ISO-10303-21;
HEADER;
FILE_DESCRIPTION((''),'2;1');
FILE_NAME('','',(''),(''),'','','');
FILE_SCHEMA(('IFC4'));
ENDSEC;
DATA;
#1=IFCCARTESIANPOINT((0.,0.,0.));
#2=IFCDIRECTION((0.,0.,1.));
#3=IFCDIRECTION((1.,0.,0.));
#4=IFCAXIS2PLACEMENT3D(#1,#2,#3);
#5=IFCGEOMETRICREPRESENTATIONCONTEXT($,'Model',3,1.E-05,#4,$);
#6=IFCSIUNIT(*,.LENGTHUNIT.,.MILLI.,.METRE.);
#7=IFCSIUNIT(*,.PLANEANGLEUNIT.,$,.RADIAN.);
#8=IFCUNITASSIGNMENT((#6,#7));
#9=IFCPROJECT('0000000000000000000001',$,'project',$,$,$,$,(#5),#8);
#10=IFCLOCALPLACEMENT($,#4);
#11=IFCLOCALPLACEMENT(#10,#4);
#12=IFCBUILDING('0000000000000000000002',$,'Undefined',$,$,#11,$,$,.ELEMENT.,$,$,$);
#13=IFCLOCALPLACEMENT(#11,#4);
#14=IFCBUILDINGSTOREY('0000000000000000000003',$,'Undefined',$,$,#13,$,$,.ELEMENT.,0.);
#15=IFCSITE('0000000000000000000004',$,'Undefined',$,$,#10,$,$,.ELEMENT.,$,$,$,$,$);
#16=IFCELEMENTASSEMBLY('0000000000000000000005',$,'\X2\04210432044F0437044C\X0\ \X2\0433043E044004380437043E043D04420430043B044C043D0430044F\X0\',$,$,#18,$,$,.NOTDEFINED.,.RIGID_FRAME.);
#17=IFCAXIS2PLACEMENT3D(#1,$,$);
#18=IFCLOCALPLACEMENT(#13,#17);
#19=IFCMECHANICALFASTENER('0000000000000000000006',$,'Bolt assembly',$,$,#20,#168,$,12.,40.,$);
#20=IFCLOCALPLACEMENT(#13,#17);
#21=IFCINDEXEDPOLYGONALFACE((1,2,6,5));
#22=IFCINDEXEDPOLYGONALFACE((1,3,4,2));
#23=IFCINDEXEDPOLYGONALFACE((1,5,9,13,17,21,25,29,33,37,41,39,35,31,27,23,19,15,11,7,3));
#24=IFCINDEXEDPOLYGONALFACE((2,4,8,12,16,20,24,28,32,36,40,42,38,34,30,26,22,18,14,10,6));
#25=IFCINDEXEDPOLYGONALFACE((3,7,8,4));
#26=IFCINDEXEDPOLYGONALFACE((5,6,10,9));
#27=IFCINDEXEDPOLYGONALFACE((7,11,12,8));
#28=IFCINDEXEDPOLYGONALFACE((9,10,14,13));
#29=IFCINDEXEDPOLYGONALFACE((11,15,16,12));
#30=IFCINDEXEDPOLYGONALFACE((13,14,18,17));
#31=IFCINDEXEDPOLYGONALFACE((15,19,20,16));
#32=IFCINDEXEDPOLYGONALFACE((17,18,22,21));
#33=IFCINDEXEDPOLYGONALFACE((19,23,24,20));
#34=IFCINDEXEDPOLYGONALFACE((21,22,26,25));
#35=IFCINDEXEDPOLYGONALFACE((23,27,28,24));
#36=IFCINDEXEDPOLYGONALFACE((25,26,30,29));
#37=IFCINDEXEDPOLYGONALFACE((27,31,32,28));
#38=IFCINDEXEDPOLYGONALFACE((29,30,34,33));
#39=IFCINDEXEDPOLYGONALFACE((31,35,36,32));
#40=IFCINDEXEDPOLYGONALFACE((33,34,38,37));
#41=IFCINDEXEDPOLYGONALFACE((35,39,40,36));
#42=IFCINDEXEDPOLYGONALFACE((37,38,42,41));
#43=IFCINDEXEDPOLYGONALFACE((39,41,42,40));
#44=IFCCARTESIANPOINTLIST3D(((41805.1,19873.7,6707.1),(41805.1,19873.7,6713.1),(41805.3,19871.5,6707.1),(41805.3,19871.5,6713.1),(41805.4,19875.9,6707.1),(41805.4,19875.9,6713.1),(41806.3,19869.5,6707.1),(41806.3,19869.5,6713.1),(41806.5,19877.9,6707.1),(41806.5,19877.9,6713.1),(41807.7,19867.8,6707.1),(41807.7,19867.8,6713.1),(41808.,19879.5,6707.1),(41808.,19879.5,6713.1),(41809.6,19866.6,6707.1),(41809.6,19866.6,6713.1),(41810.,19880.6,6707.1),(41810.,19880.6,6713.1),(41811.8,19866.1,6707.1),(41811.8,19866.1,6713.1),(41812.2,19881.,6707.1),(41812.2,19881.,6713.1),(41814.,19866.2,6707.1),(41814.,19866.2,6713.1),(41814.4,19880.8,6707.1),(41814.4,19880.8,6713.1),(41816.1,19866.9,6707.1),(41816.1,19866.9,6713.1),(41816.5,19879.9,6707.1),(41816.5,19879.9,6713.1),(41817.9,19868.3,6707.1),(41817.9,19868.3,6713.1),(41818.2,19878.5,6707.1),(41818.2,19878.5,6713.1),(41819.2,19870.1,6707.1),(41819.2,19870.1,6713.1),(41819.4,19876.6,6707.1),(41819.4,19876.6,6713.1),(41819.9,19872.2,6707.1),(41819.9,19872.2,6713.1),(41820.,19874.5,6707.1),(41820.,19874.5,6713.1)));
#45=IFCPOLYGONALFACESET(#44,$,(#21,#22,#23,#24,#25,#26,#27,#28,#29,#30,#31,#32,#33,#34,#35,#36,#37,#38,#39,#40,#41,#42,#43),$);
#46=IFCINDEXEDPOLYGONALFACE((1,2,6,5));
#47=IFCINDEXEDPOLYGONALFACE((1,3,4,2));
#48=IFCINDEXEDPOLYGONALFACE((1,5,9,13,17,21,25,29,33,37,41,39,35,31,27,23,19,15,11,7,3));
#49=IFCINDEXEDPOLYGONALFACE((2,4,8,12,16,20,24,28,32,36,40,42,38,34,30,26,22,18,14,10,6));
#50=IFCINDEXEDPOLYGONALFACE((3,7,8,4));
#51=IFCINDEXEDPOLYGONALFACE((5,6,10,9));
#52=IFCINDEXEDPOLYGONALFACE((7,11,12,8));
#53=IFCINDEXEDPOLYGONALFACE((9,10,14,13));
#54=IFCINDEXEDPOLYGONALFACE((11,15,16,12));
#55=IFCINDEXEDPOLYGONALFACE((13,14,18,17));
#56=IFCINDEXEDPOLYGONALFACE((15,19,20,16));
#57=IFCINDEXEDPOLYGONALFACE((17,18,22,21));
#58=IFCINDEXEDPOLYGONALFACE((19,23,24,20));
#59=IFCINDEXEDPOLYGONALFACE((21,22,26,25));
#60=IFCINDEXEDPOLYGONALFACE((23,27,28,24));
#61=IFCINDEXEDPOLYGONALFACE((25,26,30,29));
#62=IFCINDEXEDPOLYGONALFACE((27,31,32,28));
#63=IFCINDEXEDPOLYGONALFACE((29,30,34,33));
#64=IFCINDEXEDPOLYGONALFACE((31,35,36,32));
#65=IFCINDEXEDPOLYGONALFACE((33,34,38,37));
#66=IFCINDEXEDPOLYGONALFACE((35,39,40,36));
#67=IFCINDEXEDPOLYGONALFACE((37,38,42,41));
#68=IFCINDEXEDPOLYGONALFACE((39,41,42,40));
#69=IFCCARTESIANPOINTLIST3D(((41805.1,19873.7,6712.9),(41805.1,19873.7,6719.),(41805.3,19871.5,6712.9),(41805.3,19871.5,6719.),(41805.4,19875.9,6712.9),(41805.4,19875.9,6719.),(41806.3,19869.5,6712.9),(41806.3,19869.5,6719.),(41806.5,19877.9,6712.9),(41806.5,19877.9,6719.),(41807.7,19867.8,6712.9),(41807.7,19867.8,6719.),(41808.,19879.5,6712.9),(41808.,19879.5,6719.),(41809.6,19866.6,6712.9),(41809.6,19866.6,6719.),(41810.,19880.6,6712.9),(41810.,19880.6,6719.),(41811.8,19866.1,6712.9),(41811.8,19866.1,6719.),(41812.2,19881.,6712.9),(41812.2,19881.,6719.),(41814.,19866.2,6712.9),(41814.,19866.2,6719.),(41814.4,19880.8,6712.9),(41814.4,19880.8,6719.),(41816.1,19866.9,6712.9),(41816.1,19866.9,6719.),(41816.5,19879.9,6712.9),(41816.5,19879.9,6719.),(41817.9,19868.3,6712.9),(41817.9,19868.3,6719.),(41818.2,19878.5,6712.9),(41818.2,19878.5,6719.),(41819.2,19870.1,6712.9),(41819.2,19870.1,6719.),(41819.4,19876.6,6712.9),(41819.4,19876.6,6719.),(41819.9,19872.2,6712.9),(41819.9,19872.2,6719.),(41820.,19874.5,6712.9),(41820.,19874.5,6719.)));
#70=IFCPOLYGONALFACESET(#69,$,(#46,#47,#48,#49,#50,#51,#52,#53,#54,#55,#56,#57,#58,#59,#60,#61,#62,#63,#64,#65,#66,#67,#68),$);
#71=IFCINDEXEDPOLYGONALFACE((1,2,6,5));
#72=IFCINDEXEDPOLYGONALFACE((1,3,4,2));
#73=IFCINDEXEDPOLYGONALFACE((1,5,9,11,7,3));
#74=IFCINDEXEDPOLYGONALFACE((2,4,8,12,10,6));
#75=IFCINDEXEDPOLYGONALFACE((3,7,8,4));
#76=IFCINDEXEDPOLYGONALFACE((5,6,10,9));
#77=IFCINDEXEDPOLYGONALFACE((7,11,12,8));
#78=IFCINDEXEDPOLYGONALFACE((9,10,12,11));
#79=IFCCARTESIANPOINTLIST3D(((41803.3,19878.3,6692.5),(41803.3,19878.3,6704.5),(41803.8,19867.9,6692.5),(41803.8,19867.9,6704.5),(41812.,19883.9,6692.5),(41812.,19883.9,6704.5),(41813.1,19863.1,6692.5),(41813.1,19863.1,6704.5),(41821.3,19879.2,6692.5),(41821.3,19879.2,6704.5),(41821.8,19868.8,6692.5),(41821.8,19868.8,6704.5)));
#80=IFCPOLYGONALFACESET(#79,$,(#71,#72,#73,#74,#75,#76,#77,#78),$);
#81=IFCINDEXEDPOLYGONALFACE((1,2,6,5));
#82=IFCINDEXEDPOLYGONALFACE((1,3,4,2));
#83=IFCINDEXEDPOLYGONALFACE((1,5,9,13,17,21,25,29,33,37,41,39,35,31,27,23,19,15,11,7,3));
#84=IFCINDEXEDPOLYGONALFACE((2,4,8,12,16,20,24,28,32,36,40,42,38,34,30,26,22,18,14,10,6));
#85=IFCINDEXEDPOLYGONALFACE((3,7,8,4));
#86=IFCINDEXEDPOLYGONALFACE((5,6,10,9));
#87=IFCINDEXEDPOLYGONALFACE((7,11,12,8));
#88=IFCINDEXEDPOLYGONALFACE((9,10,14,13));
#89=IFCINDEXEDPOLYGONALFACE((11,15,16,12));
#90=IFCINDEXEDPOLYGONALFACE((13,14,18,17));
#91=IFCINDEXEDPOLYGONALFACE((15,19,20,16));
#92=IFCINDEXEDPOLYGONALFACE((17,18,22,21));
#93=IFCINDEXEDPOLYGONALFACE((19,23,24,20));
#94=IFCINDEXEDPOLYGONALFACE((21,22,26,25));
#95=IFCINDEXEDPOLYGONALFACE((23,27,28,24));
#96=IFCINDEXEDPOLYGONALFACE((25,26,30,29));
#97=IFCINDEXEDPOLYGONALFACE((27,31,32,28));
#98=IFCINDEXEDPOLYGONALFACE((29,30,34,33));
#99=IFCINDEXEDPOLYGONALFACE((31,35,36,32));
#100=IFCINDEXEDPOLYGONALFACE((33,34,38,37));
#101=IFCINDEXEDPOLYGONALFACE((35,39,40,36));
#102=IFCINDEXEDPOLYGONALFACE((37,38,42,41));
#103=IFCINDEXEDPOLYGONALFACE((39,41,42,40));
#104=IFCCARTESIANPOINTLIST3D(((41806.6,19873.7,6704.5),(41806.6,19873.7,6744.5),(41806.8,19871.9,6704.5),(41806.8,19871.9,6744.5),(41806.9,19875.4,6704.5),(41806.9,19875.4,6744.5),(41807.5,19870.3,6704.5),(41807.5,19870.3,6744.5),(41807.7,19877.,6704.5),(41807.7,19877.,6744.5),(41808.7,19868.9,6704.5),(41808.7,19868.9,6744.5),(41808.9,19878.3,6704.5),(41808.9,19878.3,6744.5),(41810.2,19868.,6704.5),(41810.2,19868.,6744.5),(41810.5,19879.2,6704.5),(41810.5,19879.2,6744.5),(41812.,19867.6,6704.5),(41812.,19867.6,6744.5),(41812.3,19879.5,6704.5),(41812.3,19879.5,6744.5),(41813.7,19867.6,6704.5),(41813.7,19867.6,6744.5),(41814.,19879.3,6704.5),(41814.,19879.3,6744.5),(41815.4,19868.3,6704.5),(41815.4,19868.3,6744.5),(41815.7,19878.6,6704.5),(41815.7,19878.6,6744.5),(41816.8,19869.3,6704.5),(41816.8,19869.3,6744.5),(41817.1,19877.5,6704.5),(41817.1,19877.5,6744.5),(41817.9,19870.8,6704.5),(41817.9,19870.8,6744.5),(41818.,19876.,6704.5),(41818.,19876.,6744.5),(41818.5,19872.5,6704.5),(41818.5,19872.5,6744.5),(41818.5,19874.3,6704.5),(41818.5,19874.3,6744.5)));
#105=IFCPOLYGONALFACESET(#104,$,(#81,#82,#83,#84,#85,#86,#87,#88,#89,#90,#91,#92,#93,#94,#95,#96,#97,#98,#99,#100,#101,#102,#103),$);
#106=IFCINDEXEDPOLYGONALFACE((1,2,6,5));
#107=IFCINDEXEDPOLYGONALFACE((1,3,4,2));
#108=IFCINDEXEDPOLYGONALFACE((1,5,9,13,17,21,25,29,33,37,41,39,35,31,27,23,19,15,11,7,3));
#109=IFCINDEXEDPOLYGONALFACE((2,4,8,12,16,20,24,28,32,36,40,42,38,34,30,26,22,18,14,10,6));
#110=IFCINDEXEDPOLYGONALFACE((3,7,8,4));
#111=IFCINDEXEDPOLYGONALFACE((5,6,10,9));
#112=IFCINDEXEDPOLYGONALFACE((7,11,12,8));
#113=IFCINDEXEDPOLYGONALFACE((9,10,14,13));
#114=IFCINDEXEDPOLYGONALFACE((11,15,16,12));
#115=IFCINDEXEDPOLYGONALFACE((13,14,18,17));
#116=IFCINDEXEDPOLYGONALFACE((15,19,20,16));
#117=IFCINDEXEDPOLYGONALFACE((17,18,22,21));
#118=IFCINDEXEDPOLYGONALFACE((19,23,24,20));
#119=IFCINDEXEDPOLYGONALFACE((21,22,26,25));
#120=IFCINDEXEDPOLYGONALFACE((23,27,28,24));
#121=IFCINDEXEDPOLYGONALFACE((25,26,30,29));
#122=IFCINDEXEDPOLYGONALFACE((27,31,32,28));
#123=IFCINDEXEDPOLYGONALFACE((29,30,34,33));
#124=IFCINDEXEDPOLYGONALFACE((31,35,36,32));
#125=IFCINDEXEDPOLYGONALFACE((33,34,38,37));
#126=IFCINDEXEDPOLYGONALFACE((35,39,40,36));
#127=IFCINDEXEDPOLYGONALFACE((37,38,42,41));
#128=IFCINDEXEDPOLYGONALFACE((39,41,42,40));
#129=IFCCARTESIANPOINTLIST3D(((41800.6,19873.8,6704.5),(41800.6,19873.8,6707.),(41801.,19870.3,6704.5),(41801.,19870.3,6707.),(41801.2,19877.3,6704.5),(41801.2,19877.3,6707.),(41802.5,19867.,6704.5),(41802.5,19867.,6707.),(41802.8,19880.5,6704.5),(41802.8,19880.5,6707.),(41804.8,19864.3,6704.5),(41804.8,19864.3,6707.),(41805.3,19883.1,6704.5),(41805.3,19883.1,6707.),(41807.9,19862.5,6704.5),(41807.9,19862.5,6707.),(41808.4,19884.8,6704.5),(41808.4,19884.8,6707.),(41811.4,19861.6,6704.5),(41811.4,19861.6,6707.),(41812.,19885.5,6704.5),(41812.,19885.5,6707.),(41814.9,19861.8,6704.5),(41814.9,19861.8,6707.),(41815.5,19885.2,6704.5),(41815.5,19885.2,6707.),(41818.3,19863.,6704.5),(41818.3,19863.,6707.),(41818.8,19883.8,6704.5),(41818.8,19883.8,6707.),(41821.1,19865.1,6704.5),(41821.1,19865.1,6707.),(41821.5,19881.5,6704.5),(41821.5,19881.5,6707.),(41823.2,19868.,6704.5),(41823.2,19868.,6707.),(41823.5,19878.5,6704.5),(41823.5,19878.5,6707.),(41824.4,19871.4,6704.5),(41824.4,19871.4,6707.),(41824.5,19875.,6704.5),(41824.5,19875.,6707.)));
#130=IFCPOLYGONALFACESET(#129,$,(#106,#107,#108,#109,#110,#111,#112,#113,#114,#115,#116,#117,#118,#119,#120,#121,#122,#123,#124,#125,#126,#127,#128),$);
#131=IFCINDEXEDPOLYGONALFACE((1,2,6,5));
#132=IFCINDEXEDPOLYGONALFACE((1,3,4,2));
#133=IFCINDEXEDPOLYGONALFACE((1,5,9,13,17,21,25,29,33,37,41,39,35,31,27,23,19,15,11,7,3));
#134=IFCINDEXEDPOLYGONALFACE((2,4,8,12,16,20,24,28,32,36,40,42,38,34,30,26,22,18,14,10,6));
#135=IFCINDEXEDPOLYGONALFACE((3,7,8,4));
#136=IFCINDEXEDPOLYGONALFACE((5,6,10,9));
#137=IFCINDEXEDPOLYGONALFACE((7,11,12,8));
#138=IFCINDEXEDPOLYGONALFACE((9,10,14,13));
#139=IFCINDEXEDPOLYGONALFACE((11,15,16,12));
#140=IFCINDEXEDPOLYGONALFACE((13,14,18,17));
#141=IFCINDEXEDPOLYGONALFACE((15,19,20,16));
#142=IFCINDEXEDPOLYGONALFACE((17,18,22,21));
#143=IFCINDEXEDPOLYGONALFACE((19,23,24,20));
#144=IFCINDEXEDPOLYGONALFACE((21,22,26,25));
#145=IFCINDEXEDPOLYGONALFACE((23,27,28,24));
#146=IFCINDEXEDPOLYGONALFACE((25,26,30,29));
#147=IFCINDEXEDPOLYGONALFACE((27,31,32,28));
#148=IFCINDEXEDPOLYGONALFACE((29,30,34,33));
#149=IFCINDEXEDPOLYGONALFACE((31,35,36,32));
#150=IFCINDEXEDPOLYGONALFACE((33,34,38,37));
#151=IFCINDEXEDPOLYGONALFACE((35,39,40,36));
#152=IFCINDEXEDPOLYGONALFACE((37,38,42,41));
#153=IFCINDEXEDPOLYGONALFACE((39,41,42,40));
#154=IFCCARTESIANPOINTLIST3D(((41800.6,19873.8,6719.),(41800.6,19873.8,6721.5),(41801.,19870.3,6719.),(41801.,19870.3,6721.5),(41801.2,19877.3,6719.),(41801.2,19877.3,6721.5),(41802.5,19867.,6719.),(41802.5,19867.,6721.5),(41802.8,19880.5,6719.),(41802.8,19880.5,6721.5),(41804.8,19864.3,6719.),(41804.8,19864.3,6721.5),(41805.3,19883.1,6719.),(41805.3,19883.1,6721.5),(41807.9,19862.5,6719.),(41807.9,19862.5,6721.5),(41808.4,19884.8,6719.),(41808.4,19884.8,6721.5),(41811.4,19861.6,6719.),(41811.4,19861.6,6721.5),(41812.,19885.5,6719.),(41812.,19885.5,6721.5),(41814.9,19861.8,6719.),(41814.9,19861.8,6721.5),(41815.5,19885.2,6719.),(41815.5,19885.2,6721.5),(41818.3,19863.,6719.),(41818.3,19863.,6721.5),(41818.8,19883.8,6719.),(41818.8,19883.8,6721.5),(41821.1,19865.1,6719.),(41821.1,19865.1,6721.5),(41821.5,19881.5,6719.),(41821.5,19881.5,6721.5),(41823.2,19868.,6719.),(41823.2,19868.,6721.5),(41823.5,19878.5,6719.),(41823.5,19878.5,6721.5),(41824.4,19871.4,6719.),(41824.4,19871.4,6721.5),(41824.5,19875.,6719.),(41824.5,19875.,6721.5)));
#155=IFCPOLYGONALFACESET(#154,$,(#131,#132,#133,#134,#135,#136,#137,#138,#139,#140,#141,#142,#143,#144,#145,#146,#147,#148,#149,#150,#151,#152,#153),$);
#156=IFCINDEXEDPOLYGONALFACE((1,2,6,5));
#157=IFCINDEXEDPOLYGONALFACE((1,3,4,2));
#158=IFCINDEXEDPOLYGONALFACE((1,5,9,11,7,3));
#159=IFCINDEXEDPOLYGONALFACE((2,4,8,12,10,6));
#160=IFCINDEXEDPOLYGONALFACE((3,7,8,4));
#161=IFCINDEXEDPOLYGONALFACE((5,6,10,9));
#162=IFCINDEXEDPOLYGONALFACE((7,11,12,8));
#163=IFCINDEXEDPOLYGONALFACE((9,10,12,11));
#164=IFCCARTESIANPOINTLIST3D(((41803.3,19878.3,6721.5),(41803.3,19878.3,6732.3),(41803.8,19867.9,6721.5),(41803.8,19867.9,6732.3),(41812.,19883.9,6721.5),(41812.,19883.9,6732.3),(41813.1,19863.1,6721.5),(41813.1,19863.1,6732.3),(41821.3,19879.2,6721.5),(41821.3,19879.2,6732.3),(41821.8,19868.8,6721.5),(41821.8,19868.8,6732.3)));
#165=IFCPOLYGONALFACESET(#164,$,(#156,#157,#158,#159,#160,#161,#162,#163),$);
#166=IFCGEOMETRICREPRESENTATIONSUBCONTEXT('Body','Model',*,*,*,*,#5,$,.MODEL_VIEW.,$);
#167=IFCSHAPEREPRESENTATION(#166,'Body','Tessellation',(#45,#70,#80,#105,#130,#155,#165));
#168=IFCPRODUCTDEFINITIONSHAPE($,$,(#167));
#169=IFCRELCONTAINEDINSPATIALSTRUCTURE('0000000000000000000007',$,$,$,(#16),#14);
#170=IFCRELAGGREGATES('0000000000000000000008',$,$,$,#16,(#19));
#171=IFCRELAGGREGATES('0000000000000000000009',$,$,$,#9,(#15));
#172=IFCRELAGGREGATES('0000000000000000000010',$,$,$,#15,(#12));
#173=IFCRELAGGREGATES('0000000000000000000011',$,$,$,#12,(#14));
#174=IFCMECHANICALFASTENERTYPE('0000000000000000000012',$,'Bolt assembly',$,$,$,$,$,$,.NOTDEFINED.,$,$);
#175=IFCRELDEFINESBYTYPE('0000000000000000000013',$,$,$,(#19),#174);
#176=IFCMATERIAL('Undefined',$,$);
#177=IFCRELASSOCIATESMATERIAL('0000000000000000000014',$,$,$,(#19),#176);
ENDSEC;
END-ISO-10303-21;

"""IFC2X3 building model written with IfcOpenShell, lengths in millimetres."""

from ifc_helpers import new_model, si_unit, frame, origin_with_axes, origin_2d_with_axis, place, context, subcontext, project, spatial, polyline, circle, outline, extrude, source, transform, mapped, material, type_object, element, aggregate, save


model = new_model("IFC2X3")

# Units and contexts
model_context = context("Model", 3, precision=1e-05, world=origin_with_axes())
body_context = subcontext(model_context, "Body", "Model", "MODEL_VIEW")
ifc_project = project(units=[si_unit("LENGTHUNIT", "METRE", prefix="MILLI"), si_unit("PLANEANGLEUNIT", "RADIAN")], contexts=[model_context])

# Site, building, storey
site_placement = place(None, origin_with_axes())
site = spatial("IfcSite", under=ifc_project, at=site_placement, Name="Undefined", CompositionType="ELEMENT")
building_placement = place(site_placement, origin_with_axes())
building = spatial("IfcBuilding", under=site, at=building_placement, Name="Undefined", CompositionType="ELEMENT")
storey_placement = place(building_placement, origin_with_axes())
storey = spatial("IfcBuildingStorey", under=building, at=storey_placement, Name="Undefined", CompositionType="ELEMENT", Elevation=0.0)

# Element assembly
assembly_1_placement = place(storey_placement, origin_with_axes())
assembly_1 = element("IfcElementAssembly", 1, at=assembly_1_placement, inside=storey, Name="Связь горизонтальная", AssemblyPlace="NOTDEFINED", PredefinedType="RIGID_FRAME")

# Mechanical fastener
ifc_material_1 = material(Name="Undefined")
mechanical_fastener_type = type_object("IfcMechanicalFastenerType", Name="Bolt assembly")
shared_shape_1 = source(origin_with_axes(), body_context, "Body", "SweptSolid", [
    extrude(circle(Radius=7.5, at=origin_2d_with_axis()), frame((0.0, 0.1, 0.0), z_axis=(0.0, 1.0, 0.0), x_axis=(1.0, 0.0, 0.0)), (0.0, 0.0, 1.0), 6.0),
    extrude(circle(Radius=7.5, at=origin_2d_with_axis()), frame((0.0, 5.9, 0.0), z_axis=(0.0, 1.0, 0.0), x_axis=(1.0, 0.0, 0.0)), (0.0, 0.0, 1.0), 6.1),
    extrude(outline(polyline([(10.4, 0.0), (5.2, 9.0), (-5.2, 9.0), (-10.4, 0.0), (-5.2, -9.0), (5.2, -9.0), (10.4, 0.0)])), frame((0.0, -14.5, 0.0), z_axis=(0.0, 1.0, 0.0), x_axis=(1.0, 0.0, 0.0)), (0.0, 0.0, 1.0), 12.0),
    extrude(circle(Radius=6.0, at=origin_2d_with_axis()), frame((0.0, -2.5, 0.0), z_axis=(0.0, 1.0, 0.0), x_axis=(1.0, 0.0, 0.0)), (0.0, 0.0, 1.0), 40.0),
    extrude(circle(Radius=12.0, at=origin_2d_with_axis()), frame((0.0, -2.5, 0.0), z_axis=(0.0, 1.0, 0.0), x_axis=(1.0, 0.0, 0.0)), (0.0, 0.0, 1.0), 2.5),
    extrude(circle(Radius=12.0, at=origin_2d_with_axis()), frame((0.0, 12.0, 0.0), z_axis=(0.0, 1.0, 0.0), x_axis=(1.0, 0.0, 0.0)), (0.0, 0.0, 1.0), 2.5),
    extrude(outline(polyline([(10.4, 0.0), (5.2, 9.0), (-5.2, 9.0), (-10.4, 0.0), (-5.2, -9.0), (5.2, -9.0), (10.4, 0.0)])), frame((0.0, 14.5, 0.0), z_axis=(0.0, 1.0, 0.0), x_axis=(1.0, 0.0, 0.0)), (0.0, 0.0, 1.0), 10.8),
])
mechanical_fastener_1_placement = place(assembly_1_placement, frame((41812.6, 19873.5, 6707.0), z_axis=(-0.542525, 0.840039, 0.0), x_axis=(-0.840039, -0.542525, 0.0)))
mechanical_fastener_1 = element("IfcMechanicalFastener", 2, at=mechanical_fastener_1_placement, type_object=mechanical_fastener_type, material=ifc_material_1, Name="Bolt assembly", NominalDiameter=12.0, NominalLength=40.0, context=body_context, shape_type="MappedRepresentation", body=[
    mapped(shared_shape_1, transform((0.0, 0.0, 0.0))),
])
aggregate(assembly_1, [mechanical_fastener_1])

save(model, "model.ifc")
